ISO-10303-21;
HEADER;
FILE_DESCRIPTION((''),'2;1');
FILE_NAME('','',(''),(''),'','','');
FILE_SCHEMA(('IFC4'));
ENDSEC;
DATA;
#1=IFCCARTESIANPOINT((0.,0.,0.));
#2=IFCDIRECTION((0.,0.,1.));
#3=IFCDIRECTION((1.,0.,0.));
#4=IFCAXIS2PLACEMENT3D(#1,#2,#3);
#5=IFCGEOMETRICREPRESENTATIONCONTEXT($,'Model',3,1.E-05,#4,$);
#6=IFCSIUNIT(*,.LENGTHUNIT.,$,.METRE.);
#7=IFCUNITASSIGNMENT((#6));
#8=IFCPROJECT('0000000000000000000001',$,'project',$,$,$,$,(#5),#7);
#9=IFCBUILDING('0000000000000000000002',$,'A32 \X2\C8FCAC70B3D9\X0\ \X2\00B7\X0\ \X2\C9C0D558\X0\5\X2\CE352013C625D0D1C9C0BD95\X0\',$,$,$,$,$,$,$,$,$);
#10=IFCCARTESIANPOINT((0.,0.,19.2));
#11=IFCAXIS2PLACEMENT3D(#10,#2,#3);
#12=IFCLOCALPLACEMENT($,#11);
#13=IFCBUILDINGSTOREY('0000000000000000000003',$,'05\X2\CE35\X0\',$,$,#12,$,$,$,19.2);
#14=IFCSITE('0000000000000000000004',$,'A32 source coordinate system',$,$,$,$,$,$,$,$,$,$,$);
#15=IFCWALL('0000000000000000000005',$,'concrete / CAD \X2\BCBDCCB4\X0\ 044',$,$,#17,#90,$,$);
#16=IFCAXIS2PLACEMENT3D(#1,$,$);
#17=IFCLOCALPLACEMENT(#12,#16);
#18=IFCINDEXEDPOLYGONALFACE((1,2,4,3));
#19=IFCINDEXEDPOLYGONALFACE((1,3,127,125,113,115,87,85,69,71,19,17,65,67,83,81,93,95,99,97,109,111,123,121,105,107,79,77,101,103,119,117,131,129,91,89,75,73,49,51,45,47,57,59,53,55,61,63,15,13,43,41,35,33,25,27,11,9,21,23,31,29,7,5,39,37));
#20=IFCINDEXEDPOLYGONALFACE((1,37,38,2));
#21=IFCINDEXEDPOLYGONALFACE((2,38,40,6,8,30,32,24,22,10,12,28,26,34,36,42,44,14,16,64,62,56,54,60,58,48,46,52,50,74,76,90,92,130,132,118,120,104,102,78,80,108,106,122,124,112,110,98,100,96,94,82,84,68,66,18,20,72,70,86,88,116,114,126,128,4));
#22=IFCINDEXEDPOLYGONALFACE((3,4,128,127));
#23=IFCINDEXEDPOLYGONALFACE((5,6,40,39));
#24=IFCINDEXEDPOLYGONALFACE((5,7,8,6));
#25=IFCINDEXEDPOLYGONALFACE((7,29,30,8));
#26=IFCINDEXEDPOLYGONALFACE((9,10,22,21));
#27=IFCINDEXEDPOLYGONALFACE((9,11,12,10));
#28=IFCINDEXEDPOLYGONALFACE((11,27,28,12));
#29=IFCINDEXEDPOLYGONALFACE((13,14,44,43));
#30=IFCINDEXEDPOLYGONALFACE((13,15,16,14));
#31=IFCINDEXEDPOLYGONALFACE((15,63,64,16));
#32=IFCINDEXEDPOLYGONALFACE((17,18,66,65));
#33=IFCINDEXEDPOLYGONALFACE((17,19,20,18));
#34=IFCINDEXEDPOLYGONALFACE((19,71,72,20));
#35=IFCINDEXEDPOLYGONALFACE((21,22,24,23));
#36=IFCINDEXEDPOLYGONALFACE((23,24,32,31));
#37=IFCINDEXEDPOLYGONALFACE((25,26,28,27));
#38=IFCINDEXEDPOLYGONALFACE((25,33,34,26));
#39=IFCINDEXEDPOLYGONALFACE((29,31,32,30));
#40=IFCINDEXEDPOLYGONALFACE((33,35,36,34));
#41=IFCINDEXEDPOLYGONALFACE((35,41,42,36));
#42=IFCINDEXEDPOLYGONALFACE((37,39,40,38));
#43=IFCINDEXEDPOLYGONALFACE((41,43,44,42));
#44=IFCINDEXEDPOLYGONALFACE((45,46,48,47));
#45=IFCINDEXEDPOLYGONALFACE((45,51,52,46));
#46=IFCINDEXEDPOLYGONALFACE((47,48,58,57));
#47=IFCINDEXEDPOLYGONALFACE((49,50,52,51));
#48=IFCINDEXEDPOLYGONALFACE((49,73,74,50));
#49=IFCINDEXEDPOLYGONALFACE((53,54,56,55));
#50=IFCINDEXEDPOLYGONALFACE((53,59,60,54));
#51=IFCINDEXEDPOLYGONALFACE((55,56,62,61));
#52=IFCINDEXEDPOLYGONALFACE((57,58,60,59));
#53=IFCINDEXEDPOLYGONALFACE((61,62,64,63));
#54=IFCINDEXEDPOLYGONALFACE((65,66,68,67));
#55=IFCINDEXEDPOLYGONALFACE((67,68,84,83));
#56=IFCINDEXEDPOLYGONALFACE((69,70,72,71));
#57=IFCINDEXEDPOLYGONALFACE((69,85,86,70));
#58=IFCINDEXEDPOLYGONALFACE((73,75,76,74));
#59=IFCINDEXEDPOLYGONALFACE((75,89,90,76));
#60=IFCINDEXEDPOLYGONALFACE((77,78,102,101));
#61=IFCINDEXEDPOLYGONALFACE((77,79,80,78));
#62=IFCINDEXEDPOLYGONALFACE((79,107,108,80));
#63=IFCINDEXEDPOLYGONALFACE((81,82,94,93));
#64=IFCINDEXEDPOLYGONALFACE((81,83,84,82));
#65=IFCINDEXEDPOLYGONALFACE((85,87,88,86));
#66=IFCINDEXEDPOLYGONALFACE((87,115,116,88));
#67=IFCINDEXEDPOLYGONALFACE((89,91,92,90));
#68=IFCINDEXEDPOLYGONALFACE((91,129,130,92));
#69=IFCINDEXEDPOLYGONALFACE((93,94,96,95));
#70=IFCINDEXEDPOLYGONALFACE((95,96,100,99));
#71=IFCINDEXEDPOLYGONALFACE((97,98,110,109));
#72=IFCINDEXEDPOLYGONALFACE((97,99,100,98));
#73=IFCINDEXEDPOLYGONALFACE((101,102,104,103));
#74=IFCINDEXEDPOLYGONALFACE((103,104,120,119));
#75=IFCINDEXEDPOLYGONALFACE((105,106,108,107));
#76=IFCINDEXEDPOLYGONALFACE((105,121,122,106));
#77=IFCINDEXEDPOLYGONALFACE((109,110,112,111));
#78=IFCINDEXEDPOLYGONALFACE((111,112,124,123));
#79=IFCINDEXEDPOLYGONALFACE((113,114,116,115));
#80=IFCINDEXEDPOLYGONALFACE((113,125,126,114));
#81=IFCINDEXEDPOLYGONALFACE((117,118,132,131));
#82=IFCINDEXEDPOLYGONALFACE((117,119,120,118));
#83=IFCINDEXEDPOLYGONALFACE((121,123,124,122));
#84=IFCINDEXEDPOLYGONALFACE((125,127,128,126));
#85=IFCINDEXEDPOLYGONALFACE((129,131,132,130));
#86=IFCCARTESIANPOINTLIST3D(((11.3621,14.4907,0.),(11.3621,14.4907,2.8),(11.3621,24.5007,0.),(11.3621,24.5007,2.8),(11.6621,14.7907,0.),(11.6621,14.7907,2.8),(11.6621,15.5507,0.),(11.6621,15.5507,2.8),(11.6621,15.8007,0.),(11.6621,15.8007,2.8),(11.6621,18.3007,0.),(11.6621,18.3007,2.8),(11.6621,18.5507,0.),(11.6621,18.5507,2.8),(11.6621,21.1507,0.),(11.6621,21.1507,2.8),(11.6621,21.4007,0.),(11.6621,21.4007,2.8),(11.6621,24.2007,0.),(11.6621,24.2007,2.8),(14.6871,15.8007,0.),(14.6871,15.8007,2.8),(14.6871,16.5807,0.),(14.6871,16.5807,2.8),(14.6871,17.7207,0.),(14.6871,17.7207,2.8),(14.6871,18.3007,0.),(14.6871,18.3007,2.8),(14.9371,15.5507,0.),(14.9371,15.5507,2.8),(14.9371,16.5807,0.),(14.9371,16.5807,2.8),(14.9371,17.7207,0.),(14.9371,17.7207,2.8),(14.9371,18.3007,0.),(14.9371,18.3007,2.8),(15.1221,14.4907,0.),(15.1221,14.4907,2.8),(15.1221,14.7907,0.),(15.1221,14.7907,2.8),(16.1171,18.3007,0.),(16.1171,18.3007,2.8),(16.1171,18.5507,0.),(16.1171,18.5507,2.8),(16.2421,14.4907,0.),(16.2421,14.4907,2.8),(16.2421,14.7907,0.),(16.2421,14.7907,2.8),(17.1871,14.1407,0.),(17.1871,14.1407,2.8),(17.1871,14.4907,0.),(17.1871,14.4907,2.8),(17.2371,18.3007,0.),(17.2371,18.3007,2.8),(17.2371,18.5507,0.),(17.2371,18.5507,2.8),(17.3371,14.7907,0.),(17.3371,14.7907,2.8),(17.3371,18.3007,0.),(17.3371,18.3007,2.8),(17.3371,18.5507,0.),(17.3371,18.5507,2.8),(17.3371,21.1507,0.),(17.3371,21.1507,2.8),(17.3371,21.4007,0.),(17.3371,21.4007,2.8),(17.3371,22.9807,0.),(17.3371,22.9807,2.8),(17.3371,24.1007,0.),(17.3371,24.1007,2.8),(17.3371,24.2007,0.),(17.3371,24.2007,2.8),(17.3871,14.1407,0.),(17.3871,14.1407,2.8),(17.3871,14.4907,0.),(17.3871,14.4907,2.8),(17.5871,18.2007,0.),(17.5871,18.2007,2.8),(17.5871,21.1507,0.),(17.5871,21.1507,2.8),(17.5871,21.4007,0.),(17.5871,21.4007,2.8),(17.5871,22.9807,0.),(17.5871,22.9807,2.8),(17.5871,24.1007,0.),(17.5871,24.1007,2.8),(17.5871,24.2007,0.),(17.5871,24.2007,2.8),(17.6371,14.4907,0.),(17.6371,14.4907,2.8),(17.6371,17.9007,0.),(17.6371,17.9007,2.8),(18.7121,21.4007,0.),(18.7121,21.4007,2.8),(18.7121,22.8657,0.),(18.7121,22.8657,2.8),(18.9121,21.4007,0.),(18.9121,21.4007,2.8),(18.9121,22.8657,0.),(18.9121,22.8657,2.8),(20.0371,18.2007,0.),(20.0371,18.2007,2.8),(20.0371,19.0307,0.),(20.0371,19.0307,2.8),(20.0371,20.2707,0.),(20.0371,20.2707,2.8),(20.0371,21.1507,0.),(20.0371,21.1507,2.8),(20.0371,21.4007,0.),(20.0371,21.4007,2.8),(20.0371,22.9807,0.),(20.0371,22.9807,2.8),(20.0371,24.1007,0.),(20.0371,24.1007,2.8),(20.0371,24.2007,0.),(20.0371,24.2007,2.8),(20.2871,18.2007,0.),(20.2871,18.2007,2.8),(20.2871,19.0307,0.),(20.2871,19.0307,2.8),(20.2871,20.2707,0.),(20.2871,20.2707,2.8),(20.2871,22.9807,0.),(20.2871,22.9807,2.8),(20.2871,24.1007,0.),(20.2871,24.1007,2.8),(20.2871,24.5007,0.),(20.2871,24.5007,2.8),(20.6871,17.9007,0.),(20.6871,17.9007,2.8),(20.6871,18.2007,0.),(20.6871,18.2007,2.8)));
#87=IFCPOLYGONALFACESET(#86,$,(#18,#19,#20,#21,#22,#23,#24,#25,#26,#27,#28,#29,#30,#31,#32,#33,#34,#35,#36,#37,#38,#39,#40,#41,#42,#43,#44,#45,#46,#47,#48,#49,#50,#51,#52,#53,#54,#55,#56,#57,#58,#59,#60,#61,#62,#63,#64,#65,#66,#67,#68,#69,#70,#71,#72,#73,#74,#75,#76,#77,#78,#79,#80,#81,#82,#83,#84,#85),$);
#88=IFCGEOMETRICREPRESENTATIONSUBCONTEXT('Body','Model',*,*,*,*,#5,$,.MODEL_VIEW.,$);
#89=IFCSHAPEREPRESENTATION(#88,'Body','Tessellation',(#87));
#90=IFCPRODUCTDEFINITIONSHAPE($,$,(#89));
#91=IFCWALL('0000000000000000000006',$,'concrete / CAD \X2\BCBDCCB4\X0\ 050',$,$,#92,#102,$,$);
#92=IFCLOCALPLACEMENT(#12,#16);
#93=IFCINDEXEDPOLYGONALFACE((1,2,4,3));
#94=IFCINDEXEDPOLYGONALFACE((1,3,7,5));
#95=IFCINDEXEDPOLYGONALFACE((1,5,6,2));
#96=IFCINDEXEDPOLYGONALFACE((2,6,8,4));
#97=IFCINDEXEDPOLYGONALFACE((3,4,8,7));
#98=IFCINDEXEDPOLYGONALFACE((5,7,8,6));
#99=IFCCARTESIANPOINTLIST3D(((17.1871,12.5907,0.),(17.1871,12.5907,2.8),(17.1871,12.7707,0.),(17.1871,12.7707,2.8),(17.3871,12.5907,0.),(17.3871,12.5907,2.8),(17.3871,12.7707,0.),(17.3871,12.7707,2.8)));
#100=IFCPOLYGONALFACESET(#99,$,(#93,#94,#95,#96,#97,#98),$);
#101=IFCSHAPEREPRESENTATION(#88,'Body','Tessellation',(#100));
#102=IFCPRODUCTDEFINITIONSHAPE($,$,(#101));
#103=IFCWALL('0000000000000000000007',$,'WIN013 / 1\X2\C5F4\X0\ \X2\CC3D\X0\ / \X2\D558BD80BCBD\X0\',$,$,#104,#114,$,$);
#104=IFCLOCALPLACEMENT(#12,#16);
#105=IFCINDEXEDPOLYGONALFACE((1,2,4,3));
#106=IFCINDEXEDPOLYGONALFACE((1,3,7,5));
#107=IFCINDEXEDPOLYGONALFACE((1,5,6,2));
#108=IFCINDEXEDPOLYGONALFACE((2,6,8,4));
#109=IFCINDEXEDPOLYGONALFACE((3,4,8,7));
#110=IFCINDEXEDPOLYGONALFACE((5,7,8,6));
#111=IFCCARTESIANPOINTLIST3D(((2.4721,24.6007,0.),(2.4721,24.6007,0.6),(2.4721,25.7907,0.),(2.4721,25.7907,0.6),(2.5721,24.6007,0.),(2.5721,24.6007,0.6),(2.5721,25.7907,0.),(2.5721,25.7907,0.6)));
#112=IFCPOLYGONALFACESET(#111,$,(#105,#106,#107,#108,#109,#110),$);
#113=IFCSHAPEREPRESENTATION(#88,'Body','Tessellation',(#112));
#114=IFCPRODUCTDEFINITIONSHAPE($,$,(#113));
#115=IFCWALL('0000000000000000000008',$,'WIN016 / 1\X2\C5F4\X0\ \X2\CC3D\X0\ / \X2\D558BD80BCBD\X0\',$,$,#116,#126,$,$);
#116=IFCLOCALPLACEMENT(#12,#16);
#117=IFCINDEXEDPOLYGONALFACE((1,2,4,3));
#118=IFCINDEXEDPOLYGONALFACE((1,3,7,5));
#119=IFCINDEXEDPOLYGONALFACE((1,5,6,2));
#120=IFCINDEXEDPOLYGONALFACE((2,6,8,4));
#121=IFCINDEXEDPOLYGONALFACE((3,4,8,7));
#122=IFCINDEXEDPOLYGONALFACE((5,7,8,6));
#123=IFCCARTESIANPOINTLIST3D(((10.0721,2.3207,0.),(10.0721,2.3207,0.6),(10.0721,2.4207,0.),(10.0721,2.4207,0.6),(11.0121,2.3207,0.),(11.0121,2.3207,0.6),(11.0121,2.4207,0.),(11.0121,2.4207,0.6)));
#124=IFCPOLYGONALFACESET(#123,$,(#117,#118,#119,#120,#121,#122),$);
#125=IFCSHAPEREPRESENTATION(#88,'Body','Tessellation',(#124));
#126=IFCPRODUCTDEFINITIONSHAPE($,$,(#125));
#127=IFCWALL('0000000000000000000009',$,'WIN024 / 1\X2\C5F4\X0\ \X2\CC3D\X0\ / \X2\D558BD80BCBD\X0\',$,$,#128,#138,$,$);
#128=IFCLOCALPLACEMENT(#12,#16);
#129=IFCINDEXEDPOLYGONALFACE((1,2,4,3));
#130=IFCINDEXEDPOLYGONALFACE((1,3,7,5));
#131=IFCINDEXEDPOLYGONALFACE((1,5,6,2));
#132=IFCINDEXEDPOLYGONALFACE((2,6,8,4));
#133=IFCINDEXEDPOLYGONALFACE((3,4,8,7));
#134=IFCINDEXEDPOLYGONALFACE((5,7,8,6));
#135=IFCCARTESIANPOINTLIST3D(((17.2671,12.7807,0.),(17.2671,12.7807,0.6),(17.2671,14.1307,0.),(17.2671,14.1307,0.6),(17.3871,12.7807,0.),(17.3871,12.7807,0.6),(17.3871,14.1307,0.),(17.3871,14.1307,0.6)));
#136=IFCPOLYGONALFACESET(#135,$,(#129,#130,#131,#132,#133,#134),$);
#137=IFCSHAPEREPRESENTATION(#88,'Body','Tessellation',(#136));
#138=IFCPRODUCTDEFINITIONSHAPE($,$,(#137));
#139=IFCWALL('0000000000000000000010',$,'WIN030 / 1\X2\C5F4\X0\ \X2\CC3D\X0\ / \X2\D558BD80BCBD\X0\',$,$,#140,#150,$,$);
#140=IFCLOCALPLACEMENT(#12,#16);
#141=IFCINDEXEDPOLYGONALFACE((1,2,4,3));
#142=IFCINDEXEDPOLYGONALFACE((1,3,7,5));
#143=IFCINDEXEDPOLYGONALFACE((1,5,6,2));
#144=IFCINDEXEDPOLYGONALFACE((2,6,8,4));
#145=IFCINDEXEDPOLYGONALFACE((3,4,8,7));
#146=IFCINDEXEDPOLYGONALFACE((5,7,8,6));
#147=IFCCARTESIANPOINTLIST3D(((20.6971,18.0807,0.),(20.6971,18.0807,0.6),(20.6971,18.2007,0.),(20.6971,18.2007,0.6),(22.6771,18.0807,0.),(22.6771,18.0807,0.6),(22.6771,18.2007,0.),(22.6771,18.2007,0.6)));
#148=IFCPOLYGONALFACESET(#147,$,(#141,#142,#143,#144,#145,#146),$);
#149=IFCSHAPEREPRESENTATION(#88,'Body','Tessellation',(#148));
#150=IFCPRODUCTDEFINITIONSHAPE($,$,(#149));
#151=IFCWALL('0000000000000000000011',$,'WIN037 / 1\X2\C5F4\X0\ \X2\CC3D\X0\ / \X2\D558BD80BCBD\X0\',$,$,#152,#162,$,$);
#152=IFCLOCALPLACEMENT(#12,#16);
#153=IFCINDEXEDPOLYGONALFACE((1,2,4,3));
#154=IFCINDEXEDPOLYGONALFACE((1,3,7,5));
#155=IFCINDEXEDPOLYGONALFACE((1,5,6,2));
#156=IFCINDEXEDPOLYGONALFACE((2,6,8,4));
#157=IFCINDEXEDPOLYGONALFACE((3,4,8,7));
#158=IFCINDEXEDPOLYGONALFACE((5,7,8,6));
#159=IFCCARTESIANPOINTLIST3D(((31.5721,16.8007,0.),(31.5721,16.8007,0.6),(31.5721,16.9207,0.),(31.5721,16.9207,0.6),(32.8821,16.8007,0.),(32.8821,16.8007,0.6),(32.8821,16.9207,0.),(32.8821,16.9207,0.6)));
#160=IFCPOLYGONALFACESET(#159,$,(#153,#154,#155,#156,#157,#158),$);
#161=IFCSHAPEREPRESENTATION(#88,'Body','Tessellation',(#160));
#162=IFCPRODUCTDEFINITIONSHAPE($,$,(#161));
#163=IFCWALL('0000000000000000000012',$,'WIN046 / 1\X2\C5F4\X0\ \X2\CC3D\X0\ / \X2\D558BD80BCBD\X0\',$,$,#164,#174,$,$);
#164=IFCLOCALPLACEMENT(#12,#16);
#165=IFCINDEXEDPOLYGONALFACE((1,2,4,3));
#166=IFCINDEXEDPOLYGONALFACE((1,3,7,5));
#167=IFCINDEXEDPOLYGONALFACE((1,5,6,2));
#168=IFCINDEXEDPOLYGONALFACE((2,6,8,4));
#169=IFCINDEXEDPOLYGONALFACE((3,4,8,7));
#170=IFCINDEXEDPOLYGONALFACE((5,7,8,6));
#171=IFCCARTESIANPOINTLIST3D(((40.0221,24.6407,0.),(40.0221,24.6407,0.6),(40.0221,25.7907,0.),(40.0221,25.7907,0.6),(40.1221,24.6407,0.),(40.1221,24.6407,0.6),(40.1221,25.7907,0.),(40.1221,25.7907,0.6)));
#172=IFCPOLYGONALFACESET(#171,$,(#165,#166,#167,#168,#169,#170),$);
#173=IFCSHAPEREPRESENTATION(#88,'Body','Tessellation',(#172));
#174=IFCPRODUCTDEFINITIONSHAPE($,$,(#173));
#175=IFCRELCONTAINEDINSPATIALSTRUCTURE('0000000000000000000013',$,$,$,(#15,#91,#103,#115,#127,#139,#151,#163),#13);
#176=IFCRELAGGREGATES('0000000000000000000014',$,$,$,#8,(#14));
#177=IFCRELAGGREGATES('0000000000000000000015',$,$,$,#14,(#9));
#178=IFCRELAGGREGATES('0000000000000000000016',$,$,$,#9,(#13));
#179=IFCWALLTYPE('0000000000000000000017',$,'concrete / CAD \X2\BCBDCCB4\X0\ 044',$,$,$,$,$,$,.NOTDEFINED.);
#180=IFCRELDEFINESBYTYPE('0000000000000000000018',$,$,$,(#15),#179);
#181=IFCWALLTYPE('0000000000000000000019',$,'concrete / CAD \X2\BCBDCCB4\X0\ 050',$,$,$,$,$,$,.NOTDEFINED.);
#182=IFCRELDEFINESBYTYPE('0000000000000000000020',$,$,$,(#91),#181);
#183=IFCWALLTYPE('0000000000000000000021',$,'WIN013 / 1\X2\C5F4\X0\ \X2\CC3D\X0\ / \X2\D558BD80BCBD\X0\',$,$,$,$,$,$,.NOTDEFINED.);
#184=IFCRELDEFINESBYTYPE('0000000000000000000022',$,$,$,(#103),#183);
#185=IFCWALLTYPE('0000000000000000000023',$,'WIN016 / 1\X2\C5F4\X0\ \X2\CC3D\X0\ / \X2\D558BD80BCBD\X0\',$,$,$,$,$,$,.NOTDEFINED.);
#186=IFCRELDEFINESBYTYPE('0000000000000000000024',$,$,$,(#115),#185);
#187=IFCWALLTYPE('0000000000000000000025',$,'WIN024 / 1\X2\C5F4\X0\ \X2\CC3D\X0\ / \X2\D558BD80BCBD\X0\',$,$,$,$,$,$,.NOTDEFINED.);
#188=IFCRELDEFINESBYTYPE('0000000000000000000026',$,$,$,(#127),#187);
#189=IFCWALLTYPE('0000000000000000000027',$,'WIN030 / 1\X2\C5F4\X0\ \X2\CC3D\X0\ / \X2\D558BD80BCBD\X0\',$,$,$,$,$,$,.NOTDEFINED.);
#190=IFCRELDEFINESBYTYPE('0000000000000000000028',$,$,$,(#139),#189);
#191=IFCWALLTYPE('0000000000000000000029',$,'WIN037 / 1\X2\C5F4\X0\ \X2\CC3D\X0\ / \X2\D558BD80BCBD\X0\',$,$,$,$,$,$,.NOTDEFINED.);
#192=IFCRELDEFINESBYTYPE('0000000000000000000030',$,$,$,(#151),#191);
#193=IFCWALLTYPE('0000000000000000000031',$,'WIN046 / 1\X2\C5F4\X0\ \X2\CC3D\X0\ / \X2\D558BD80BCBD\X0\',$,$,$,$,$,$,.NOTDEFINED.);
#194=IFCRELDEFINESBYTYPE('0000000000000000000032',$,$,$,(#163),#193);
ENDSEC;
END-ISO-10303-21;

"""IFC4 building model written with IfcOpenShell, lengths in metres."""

from ifc_helpers import new_model, si_unit, frame, origin, origin_with_axes, place, context, subcontext, project, spatial, polyline, outline, extrude, source, transform, mapped, type_object, type_shapes, element, save


model = new_model("IFC4")

# Units and contexts
model_context = context("Model", 3, precision=1e-05, world=origin_with_axes())
body_context = subcontext(model_context, "Body", "Model", "MODEL_VIEW")
ifc_project = project(units=[si_unit("LENGTHUNIT", "METRE")], contexts=[model_context])

# Site, building, storey
site = spatial("IfcSite", under=ifc_project, Name="A32 source coordinate system")
building = spatial("IfcBuilding", under=site, Name="A32 주거동 · 지하5층–옥탑지붕")
storey_placement = place(None, frame((0.0, 0.0, 19.2), z_axis=(0.0, 0.0, 1.0), x_axis=(1.0, 0.0, 0.0)))
storey = spatial("IfcBuildingStorey", under=building, at=storey_placement, Name="05층", Elevation=19.2)

# Walls
wall_type_1 = type_object("IfcWallType", Name="concrete / CAD 벽체 044", PredefinedType="NOTDEFINED")
shared_shape_1 = source(origin(), body_context, "Body", "SweptSolid", [
    extrude(outline(polyline([(17.3371, 21.4007), (17.3371, 22.9807), (17.5871, 22.9807), (17.5871, 21.4007), (18.7121, 21.4007), (18.7121, 22.8657), (18.9121, 22.8657), (18.9121, 21.4007), (20.0371, 21.4007), (20.0371, 22.9807), (20.2871, 22.9807), (20.2871, 20.2707), (20.0371, 20.2707), (20.0371, 21.1507), (17.5871, 21.1507), (17.5871, 18.2007), (20.0371, 18.2007), (20.0371, 19.0307), (20.2871, 19.0307), (20.2871, 18.2007), (20.6871, 18.2007), (20.6871, 17.9007), (17.6371, 17.9007), (17.6371, 14.4907), (17.3871, 14.4907), (17.3871, 14.1407), (17.1871, 14.1407), (17.1871, 14.4907), (16.2421, 14.4907), (16.2421, 14.7907), (17.3371, 14.7907), (17.3371, 18.3007), (17.2371, 18.3007), (17.2371, 18.5507), (17.3371, 18.5507), (17.3371, 21.1507), (11.6621, 21.1507), (11.6621, 18.5507), (16.1171, 18.5507), (16.1171, 18.3007), (14.9371, 18.3007), (14.9371, 17.7207), (14.6871, 17.7207), (14.6871, 18.3007), (11.6621, 18.3007), (11.6621, 15.8007), (14.6871, 15.8007), (14.6871, 16.5807), (14.9371, 16.5807), (14.9371, 15.5507), (11.6621, 15.5507), (11.6621, 14.7907), (15.1221, 14.7907), (15.1221, 14.4907), (11.3621, 14.4907), (11.3621, 24.5007), (20.2871, 24.5007), (20.2871, 24.1007), (20.0371, 24.1007), (20.0371, 24.2007), (17.5871, 24.2007), (17.5871, 24.1007), (17.3371, 24.1007), (17.3371, 24.2007), (11.6621, 24.2007), (11.6621, 21.4007), (17.3371, 21.4007)])), origin(), (0.0, 0.0, 1.0), 2.8),
])
type_shapes(wall_type_1, [shared_shape_1])
wall_1_placement = place(storey_placement, origin_with_axes())
element("IfcWall", 1, at=wall_1_placement, inside=storey, type_object=wall_type_1, Name="concrete / CAD 벽체 044", context=body_context, shape_type="MappedRepresentation", body=[
    mapped(shared_shape_1, transform((0.0, 0.0, 0.0), scale=1.0)),
])
wall_type_2 = type_object("IfcWallType", Name="concrete / CAD 벽체 050", PredefinedType="NOTDEFINED")
shared_shape_2 = source(origin(), body_context, "Body", "SweptSolid", [
    extrude(outline(polyline([(17.3871, 12.5907), (17.1871, 12.5907), (17.1871, 12.7707), (17.3871, 12.7707), (17.3871, 12.5907)])), origin(), (0.0, 0.0, 1.0), 2.8),
])
type_shapes(wall_type_2, [shared_shape_2])
wall_2_placement = place(storey_placement, origin_with_axes())
element("IfcWall", 2, at=wall_2_placement, inside=storey, type_object=wall_type_2, Name="concrete / CAD 벽체 050", context=body_context, shape_type="MappedRepresentation", body=[
    mapped(shared_shape_2, transform((0.0, 0.0, 0.0), scale=1.0)),
])
wall_type_3 = type_object("IfcWallType", Name="WIN013 / 1열 창 / 하부벽", PredefinedType="NOTDEFINED")
shared_shape_3 = source(origin(), body_context, "Body", "SweptSolid", [
    extrude(outline(polyline([(2.5721, 25.7907), (2.5721, 24.6007), (2.4721, 24.6007), (2.4721, 25.7907), (2.5721, 25.7907)])), origin(), (0.0, 0.0, 1.0), 0.6),
])
type_shapes(wall_type_3, [shared_shape_3])
wall_3_placement = place(storey_placement, origin_with_axes())
element("IfcWall", 3, at=wall_3_placement, inside=storey, type_object=wall_type_3, Name="WIN013 / 1열 창 / 하부벽", context=body_context, shape_type="MappedRepresentation", body=[
    mapped(shared_shape_3, transform((0.0, 0.0, 0.0), scale=1.0)),
])
wall_type_4 = type_object("IfcWallType", Name="WIN016 / 1열 창 / 하부벽", PredefinedType="NOTDEFINED")
shared_shape_4 = source(origin(), body_context, "Body", "SweptSolid", [
    extrude(outline(polyline([(11.0121, 2.4207), (11.0121, 2.3207), (10.0721, 2.3207), (10.0721, 2.4207), (11.0121, 2.4207)])), origin(), (0.0, 0.0, 1.0), 0.6),
])
type_shapes(wall_type_4, [shared_shape_4])
wall_4_placement = place(storey_placement, origin_with_axes())
element("IfcWall", 4, at=wall_4_placement, inside=storey, type_object=wall_type_4, Name="WIN016 / 1열 창 / 하부벽", context=body_context, shape_type="MappedRepresentation", body=[
    mapped(shared_shape_4, transform((0.0, 0.0, 0.0), scale=1.0)),
])
wall_type_5 = type_object("IfcWallType", Name="WIN024 / 1열 창 / 하부벽", PredefinedType="NOTDEFINED")
shared_shape_5 = source(origin(), body_context, "Body", "SweptSolid", [
    extrude(outline(polyline([(17.3871, 14.1307), (17.3871, 12.7807), (17.2671, 12.7807), (17.2671, 14.1307), (17.3871, 14.1307)])), origin(), (0.0, 0.0, 1.0), 0.6),
])
type_shapes(wall_type_5, [shared_shape_5])
wall_5_placement = place(storey_placement, origin_with_axes())
element("IfcWall", 5, at=wall_5_placement, inside=storey, type_object=wall_type_5, Name="WIN024 / 1열 창 / 하부벽", context=body_context, shape_type="MappedRepresentation", body=[
    mapped(shared_shape_5, transform((0.0, 0.0, 0.0), scale=1.0)),
])
wall_type_6 = type_object("IfcWallType", Name="WIN030 / 1열 창 / 하부벽", PredefinedType="NOTDEFINED")
shared_shape_6 = source(origin(), body_context, "Body", "SweptSolid", [
    extrude(outline(polyline([(22.6771, 18.2007), (22.6771, 18.0807), (20.6971, 18.0807), (20.6971, 18.2007), (22.6771, 18.2007)])), origin(), (0.0, 0.0, 1.0), 0.6),
])
type_shapes(wall_type_6, [shared_shape_6])
wall_6_placement = place(storey_placement, origin_with_axes())
element("IfcWall", 6, at=wall_6_placement, inside=storey, type_object=wall_type_6, Name="WIN030 / 1열 창 / 하부벽", context=body_context, shape_type="MappedRepresentation", body=[
    mapped(shared_shape_6, transform((0.0, 0.0, 0.0), scale=1.0)),
])
wall_type_7 = type_object("IfcWallType", Name="WIN037 / 1열 창 / 하부벽", PredefinedType="NOTDEFINED")
shared_shape_7 = source(origin(), body_context, "Body", "SweptSolid", [
    extrude(outline(polyline([(32.8821, 16.9207), (32.8821, 16.8007), (31.5721, 16.8007), (31.5721, 16.9207), (32.8821, 16.9207)])), origin(), (0.0, 0.0, 1.0), 0.6),
])
type_shapes(wall_type_7, [shared_shape_7])
wall_7_placement = place(storey_placement, origin_with_axes())
element("IfcWall", 7, at=wall_7_placement, inside=storey, type_object=wall_type_7, Name="WIN037 / 1열 창 / 하부벽", context=body_context, shape_type="MappedRepresentation", body=[
    mapped(shared_shape_7, transform((0.0, 0.0, 0.0), scale=1.0)),
])
wall_type_8 = type_object("IfcWallType", Name="WIN046 / 1열 창 / 하부벽", PredefinedType="NOTDEFINED")
shared_shape_8 = source(origin(), body_context, "Body", "SweptSolid", [
    extrude(outline(polyline([(40.1221, 25.7907), (40.1221, 24.6407), (40.0221, 24.6407), (40.0221, 25.7907), (40.1221, 25.7907)])), origin(), (0.0, 0.0, 1.0), 0.6),
])
type_shapes(wall_type_8, [shared_shape_8])
wall_8_placement = place(storey_placement, origin_with_axes())
element("IfcWall", 8, at=wall_8_placement, inside=storey, type_object=wall_type_8, Name="WIN046 / 1열 창 / 하부벽", context=body_context, shape_type="MappedRepresentation", body=[
    mapped(shared_shape_8, transform((0.0, 0.0, 0.0), scale=1.0)),
])

save(model, "model.ifc")
